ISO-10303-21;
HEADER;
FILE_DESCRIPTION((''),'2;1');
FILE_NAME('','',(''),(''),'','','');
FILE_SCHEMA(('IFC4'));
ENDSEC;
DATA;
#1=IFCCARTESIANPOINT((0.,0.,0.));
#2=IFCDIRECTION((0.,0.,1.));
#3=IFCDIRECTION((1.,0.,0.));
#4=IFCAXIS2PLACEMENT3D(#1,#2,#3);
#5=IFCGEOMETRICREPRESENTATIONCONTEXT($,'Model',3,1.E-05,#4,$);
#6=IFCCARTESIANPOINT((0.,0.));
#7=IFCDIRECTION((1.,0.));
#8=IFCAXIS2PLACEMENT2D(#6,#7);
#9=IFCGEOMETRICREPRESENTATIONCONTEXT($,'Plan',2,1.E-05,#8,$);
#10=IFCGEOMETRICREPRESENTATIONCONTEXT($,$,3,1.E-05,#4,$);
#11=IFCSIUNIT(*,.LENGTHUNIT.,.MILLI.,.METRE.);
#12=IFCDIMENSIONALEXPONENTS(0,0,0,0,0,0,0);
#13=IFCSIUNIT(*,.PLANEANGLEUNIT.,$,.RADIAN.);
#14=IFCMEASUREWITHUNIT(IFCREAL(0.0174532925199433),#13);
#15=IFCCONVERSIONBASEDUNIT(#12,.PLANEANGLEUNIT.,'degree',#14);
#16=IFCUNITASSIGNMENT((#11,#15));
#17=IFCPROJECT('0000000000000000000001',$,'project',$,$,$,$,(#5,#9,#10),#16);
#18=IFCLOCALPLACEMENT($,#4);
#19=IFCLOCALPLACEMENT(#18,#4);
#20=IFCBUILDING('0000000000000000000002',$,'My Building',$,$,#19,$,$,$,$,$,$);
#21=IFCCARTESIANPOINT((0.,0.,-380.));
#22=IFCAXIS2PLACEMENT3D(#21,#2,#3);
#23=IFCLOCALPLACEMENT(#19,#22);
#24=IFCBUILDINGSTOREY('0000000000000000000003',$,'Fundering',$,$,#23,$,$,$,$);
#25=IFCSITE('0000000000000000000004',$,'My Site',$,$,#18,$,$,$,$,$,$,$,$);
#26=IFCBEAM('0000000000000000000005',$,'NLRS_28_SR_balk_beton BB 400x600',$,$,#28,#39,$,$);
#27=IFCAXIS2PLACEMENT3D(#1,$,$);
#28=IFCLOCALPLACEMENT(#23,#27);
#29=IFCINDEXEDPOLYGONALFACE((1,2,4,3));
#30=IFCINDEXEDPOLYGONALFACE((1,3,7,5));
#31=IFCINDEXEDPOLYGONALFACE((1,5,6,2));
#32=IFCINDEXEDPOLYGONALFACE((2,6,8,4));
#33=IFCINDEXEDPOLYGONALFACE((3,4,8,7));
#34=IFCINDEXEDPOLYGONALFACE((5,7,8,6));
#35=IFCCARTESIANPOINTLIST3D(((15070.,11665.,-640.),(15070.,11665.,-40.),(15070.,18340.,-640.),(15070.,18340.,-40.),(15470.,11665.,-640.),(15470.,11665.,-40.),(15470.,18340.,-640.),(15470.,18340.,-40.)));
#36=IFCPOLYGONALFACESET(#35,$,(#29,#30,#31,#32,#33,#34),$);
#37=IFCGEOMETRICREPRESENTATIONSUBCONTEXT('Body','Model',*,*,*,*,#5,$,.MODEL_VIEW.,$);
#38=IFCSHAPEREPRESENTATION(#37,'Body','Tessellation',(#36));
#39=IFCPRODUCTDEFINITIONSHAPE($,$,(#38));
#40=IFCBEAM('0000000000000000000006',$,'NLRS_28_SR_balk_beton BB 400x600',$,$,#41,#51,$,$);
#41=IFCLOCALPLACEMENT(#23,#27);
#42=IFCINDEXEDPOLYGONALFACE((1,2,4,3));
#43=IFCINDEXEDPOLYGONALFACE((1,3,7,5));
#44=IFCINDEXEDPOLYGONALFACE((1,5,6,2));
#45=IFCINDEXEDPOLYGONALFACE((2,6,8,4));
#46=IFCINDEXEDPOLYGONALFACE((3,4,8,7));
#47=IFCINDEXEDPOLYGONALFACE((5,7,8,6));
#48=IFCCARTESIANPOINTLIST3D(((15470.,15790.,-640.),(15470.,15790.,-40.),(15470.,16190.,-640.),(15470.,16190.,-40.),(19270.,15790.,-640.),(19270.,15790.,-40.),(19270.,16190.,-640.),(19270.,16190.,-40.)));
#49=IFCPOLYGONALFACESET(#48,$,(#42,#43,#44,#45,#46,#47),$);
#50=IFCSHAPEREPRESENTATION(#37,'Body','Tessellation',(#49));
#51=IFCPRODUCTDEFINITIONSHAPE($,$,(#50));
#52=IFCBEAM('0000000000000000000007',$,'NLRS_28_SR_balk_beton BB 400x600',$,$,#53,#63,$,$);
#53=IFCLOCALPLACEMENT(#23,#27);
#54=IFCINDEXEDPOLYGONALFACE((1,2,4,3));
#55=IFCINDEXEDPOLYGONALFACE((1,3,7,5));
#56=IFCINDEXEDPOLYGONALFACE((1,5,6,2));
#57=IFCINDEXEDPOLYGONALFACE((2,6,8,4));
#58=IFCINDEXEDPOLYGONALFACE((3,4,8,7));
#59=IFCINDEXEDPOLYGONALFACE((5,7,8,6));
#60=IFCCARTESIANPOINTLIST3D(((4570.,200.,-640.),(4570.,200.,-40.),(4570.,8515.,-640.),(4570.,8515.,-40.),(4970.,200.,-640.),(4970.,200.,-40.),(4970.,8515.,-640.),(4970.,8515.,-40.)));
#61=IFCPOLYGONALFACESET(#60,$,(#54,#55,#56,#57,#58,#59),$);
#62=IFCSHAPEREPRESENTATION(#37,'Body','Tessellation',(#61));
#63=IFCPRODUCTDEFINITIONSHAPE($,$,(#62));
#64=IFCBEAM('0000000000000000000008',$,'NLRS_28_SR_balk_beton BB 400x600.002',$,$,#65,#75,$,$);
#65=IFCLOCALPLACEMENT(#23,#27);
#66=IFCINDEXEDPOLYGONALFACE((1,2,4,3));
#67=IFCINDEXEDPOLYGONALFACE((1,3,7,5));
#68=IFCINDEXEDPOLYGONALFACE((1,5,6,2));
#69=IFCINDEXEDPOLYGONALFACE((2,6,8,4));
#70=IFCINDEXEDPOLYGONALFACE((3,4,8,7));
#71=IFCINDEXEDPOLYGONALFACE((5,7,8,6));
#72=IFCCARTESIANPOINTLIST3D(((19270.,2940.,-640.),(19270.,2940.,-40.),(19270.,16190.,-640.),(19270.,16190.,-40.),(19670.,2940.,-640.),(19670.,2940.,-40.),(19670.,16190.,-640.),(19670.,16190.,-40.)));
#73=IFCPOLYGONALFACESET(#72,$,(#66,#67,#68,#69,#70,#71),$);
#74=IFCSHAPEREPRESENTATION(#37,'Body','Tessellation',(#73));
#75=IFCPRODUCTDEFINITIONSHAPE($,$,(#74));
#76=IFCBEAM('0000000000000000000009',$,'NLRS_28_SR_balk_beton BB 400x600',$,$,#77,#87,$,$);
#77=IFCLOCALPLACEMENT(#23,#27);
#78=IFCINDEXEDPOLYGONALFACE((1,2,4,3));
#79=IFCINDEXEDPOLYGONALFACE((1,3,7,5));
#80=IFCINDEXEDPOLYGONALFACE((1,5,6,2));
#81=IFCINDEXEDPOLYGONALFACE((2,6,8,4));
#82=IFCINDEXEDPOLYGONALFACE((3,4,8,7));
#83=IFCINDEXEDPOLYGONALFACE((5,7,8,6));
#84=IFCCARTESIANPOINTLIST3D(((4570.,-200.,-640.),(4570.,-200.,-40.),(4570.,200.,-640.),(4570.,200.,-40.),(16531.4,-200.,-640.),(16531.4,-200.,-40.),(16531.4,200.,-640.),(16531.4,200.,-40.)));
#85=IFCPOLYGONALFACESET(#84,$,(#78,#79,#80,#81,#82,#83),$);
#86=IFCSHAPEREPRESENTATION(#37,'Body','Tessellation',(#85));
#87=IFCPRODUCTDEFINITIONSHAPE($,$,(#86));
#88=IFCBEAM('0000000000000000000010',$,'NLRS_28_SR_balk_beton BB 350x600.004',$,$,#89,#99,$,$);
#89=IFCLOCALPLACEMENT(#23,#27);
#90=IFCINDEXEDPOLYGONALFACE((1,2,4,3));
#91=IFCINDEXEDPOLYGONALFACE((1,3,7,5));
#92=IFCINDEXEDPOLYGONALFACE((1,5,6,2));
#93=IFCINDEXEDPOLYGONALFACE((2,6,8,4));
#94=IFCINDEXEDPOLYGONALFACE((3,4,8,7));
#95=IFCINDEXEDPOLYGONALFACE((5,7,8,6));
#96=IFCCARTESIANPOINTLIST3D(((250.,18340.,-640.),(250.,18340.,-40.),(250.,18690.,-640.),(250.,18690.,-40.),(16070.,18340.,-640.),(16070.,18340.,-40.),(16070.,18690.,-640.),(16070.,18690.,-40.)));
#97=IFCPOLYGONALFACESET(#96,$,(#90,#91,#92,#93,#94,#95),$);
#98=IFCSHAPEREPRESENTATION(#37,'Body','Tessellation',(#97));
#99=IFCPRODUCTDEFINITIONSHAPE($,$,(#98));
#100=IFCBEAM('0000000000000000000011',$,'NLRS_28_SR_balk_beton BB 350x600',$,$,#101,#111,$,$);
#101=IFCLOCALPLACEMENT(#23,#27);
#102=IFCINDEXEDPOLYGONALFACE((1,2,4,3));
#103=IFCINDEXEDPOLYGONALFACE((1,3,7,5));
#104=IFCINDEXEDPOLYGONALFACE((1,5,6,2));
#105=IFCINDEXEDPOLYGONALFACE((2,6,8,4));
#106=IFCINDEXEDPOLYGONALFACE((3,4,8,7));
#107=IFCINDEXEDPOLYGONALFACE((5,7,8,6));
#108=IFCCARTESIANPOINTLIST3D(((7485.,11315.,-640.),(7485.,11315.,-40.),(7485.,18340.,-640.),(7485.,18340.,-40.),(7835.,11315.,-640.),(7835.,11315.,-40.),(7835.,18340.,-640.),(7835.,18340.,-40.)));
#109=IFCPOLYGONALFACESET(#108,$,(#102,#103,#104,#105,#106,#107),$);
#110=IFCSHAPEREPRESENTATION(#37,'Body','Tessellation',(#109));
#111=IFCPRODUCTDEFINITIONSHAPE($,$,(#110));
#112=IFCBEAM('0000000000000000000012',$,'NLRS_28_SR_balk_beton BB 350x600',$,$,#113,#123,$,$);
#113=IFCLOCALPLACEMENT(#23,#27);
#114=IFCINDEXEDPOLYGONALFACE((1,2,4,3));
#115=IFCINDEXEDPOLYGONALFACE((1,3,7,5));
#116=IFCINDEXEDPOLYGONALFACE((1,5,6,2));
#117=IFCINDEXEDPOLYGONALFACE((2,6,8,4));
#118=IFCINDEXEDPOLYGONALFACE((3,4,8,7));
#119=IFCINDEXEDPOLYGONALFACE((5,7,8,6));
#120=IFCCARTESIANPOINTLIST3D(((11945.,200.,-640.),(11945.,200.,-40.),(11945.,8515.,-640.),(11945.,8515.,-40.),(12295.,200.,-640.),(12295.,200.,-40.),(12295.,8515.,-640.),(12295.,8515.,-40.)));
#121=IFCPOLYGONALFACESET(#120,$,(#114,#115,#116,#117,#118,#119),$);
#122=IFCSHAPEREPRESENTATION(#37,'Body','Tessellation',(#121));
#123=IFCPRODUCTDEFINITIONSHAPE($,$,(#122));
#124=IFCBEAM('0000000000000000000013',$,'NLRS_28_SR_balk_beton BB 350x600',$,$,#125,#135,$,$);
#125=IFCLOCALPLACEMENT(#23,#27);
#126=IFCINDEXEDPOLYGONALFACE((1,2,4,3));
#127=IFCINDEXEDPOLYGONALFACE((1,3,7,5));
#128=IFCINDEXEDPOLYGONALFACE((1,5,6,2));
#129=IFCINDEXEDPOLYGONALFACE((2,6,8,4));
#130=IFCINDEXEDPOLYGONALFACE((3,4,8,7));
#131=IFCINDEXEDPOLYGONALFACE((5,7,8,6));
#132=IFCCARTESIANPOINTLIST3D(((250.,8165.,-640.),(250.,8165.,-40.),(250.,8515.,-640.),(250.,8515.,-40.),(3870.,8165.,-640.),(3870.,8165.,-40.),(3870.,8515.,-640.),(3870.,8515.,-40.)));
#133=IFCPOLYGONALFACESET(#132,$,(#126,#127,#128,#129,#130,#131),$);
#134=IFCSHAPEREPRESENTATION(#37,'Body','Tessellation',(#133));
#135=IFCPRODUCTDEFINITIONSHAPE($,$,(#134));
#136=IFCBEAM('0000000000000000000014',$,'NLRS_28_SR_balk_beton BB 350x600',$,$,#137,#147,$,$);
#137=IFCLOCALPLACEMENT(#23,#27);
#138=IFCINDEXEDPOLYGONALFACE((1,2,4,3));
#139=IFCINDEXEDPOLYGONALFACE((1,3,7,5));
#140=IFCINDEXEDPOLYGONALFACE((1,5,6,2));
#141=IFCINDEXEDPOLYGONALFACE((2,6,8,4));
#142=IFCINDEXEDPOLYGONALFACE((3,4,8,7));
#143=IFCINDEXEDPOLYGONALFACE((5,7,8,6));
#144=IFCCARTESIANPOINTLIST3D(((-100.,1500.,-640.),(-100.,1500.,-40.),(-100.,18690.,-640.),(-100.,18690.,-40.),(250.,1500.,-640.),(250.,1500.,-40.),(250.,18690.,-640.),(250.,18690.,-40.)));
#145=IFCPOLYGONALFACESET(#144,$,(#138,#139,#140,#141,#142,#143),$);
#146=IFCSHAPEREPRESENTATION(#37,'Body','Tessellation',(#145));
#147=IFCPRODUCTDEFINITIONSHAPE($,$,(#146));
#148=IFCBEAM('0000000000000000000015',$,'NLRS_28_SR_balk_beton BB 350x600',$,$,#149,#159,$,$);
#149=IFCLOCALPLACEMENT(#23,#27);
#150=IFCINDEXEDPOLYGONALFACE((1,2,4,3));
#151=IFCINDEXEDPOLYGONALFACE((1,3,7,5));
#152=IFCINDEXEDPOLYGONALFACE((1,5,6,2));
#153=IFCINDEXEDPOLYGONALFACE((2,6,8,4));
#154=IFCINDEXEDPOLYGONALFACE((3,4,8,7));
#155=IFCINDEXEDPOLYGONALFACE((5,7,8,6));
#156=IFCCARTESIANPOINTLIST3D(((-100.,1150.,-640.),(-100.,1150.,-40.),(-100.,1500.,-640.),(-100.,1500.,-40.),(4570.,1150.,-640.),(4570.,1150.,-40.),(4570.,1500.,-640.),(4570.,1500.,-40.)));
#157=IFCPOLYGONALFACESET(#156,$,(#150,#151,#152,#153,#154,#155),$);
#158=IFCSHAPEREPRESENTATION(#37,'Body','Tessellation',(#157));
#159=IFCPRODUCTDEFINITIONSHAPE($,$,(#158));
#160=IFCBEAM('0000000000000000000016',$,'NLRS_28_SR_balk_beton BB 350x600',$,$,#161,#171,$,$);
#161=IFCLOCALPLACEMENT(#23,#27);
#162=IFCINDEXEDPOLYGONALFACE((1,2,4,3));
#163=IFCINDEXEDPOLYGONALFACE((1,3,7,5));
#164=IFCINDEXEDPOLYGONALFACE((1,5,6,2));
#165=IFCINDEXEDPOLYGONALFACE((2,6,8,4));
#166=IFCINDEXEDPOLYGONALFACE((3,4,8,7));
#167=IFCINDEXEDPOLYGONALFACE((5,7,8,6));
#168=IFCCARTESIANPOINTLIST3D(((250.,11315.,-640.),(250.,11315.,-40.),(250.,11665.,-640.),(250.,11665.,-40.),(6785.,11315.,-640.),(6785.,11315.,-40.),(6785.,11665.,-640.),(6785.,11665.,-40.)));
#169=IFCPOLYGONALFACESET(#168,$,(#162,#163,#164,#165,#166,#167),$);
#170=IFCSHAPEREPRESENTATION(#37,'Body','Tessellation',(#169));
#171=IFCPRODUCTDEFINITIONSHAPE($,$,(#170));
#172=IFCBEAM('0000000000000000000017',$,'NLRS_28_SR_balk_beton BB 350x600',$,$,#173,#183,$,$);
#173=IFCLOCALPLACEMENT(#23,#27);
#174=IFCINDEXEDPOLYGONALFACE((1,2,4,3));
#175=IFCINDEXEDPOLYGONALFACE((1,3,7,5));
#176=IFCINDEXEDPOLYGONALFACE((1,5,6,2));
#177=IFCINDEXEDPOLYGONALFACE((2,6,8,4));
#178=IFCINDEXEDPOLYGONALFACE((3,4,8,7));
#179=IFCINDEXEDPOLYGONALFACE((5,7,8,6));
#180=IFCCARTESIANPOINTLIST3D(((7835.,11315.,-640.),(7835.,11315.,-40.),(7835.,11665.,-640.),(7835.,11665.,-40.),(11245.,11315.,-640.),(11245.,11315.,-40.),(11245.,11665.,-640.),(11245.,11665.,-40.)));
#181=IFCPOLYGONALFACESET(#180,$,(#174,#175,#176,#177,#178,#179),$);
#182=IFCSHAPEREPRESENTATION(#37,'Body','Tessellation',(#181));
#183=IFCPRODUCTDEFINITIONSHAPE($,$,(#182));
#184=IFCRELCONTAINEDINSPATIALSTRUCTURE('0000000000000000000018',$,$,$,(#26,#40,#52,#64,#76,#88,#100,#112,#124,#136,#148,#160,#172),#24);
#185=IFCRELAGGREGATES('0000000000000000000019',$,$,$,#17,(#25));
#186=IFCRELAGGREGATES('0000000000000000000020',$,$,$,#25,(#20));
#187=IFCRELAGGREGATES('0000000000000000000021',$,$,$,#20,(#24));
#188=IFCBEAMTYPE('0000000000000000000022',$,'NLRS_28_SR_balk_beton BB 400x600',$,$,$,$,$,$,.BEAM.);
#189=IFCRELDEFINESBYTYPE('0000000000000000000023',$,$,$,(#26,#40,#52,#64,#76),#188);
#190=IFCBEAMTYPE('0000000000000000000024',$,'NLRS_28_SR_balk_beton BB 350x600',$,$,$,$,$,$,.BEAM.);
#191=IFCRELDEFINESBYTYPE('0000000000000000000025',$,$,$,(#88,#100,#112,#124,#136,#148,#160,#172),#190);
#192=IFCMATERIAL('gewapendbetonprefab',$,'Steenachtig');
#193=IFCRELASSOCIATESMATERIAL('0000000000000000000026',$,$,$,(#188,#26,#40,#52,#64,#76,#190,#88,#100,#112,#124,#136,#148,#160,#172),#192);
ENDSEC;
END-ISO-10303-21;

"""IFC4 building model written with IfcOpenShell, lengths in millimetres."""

from ifc_helpers import new_model, entity, si_unit, converted_unit, frame, origin_with_axes, origin_2d_with_axis, place, context, subcontext, project, spatial, rectangle, extrude, material, material_profile, profile_set, profile_usage, type_object, element, save


model = new_model("IFC4")

# Units and contexts
model_context = context("Model", 3, precision=1e-05, world=origin_with_axes())
plan_context = context("Plan", 2, precision=1e-05, world=origin_2d_with_axis())
context_of_model = context(None, 3, precision=1e-05, world=origin_with_axes())
body_context = subcontext(model_context, "Body", "Model", "MODEL_VIEW")
ifc_project = project(units=[si_unit("LENGTHUNIT", "METRE", prefix="MILLI"), converted_unit("PLANEANGLEUNIT", "degree", entity("IfcReal", 0.0174532925199433), si_unit("PLANEANGLEUNIT", "RADIAN"), dimensions=[0, 0, 0, 0, 0, 0, 0])], contexts=[model_context, plan_context, context_of_model])

# Site, building, storey
site_placement = place(None, origin_with_axes())
site = spatial("IfcSite", under=ifc_project, at=site_placement, Name="My Site")
building_placement = place(site_placement, origin_with_axes())
building = spatial("IfcBuilding", under=site, at=building_placement, Name="My Building")
storey_placement = place(building_placement, frame((0.0, 0.0, -380.0), z_axis=(0.0, 0.0, 1.0), x_axis=(1.0, 0.0, 0.0)))
storey = spatial("IfcBuildingStorey", under=building, at=storey_placement, Name="Fundering")

# Beams
ifc_material_1 = material(Name="gewapendbetonprefab", Category="Steenachtig")
ifc_material_profile_1 = material_profile(ifc_material_1, rectangle(XDim=400.0, YDim=600.0))
ifc_profile_set_1 = profile_set([ifc_material_profile_1], Name="NLRS_28_SR_balk_beton BB 400x600")
ifc_profile_usage_1 = profile_usage(ifc_profile_set_1, cardinal=8)
beam_type_1 = type_object("IfcBeamType", Name="NLRS_28_SR_balk_beton BB 400x600", PredefinedType="BEAM", material=ifc_profile_set_1)
beam_1_placement = place(storey_placement, frame((15270.0, 11665.0, -40.0), z_axis=(0.0, 1.0, 0.0), x_axis=(-1.0, 0.0, 0.0)))
element("IfcBeam", 1, at=beam_1_placement, inside=storey, type_object=beam_type_1, material=ifc_profile_usage_1, Name="NLRS_28_SR_balk_beton BB 400x600", context=body_context, shape_type="SweptSolid", body=[
    extrude(rectangle(XDim=400.0, YDim=600.0), frame((0.0, -300.0, 0.0), z_axis=(0.0, 0.0, 1.0), x_axis=(1.0, 0.0, 0.0)), (0.0, 0.0, 1.0), 6675.0),
])
ifc_profile_usage_2 = profile_usage(ifc_profile_set_1, cardinal=8)
beam_2_placement = place(storey_placement, frame((19270.0, 15990.0, -40.0), z_axis=(-1.0, 0.0, 0.0), x_axis=(0.0, -1.0, 0.0)))
element("IfcBeam", 2, at=beam_2_placement, inside=storey, type_object=beam_type_1, material=ifc_profile_usage_2, Name="NLRS_28_SR_balk_beton BB 400x600", context=body_context, shape_type="SweptSolid", body=[
    extrude(rectangle(XDim=400.0, YDim=600.0), frame((0.0, -300.0, 0.0), z_axis=(0.0, 0.0, 1.0), x_axis=(1.0, 0.0, 0.0)), (0.0, 0.0, 1.0), 3800.0),
])
ifc_profile_usage_3 = profile_usage(ifc_profile_set_1, cardinal=8)
beam_3_placement = place(storey_placement, frame((4770.0, 200.0, -40.0), z_axis=(0.0, 1.0, 0.0), x_axis=(-1.0, 0.0, 0.0)))
element("IfcBeam", 3, at=beam_3_placement, inside=storey, type_object=beam_type_1, material=ifc_profile_usage_3, Name="NLRS_28_SR_balk_beton BB 400x600", context=body_context, shape_type="SweptSolid", body=[
    extrude(rectangle(XDim=400.0, YDim=600.0), frame((0.0, -300.0, 0.0), z_axis=(0.0, 0.0, 1.0), x_axis=(1.0, 0.0, 0.0)), (0.0, 0.0, 1.0), 8315.0),
])
ifc_profile_usage_4 = profile_usage(ifc_profile_set_1, cardinal=8)
beam_4_placement = place(storey_placement, frame((19470.0, 2940.0, -40.0), z_axis=(0.0, 1.0, 0.0), x_axis=(-1.0, 0.0, 0.0)))
element("IfcBeam", 4, at=beam_4_placement, inside=storey, type_object=beam_type_1, material=ifc_profile_usage_4, Name="NLRS_28_SR_balk_beton BB 400x600.002", context=body_context, shape_type="SweptSolid", body=[
    extrude(rectangle(XDim=400.0, YDim=600.0), frame((0.0, -300.0, 0.0), z_axis=(0.0, 0.0, 1.0), x_axis=(1.0, 0.0, 0.0)), (0.0, 0.0, 1.0), 13250.0),
])
ifc_profile_usage_5 = profile_usage(ifc_profile_set_1, cardinal=8)
beam_5_placement = place(storey_placement, frame((4570.0, 0.0, -40.0), z_axis=(1.0, 0.0, 0.0), x_axis=(0.0, 1.0, 0.0)))
element("IfcBeam", 5, at=beam_5_placement, inside=storey, type_object=beam_type_1, material=ifc_profile_usage_5, Name="NLRS_28_SR_balk_beton BB 400x600", context=body_context, shape_type="SweptSolid", body=[
    extrude(rectangle(XDim=400.0, YDim=600.0), frame((0.0, -300.0, 0.0), z_axis=(0.0, 0.0, 1.0), x_axis=(1.0, 0.0, 0.0)), (0.0, 0.0, 1.0), 11961.4),
])
ifc_material_profile_2 = material_profile(ifc_material_1, rectangle(XDim=350.0, YDim=600.0))
ifc_profile_set_2 = profile_set([ifc_material_profile_2], Name="NLRS_28_SR_balk_beton BB 350x600")
ifc_profile_usage_6 = profile_usage(ifc_profile_set_2, cardinal=8)
beam_type_2 = type_object("IfcBeamType", Name="NLRS_28_SR_balk_beton BB 350x600", PredefinedType="BEAM", material=ifc_profile_set_2)
beam_6_placement = place(storey_placement, frame((250.0, 18515.0, -40.0), z_axis=(1.0, 0.0, 0.0), x_axis=(0.0, 1.0, 0.0)))
element("IfcBeam", 6, at=beam_6_placement, inside=storey, type_object=beam_type_2, material=ifc_profile_usage_6, Name="NLRS_28_SR_balk_beton BB 350x600.004", context=body_context, shape_type="SweptSolid", body=[
    extrude(rectangle(XDim=350.0, YDim=600.0), frame((0.0, -300.0, 0.0), z_axis=(0.0, 0.0, 1.0), x_axis=(1.0, 0.0, 0.0)), (0.0, 0.0, 1.0), 15820.0),
])
ifc_profile_usage_7 = profile_usage(ifc_profile_set_2, cardinal=8)
beam_7_placement = place(storey_placement, frame((7660.0, 11315.0, -40.0), z_axis=(0.0, 1.0, 0.0), x_axis=(-1.0, 0.0, 0.0)))
element("IfcBeam", 7, at=beam_7_placement, inside=storey, type_object=beam_type_2, material=ifc_profile_usage_7, Name="NLRS_28_SR_balk_beton BB 350x600", context=body_context, shape_type="SweptSolid", body=[
    extrude(rectangle(XDim=350.0, YDim=600.0), frame((0.0, -300.0, 0.0), z_axis=(0.0, 0.0, 1.0), x_axis=(1.0, 0.0, 0.0)), (0.0, 0.0, 1.0), 7025.0),
])
ifc_profile_usage_8 = profile_usage(ifc_profile_set_2)
beam_8_placement = place(storey_placement, frame((12120.0, 200.0, -340.0), z_axis=(0.0, 1.0, 0.0), x_axis=(-1.0, 0.0, 0.0)))
element("IfcBeam", 8, at=beam_8_placement, inside=storey, type_object=beam_type_2, material=ifc_profile_usage_8, Name="NLRS_28_SR_balk_beton BB 350x600", context=body_context, shape_type="SweptSolid", body=[
    extrude(rectangle(XDim=350.0, YDim=600.0), origin_with_axes(), (0.0, 0.0, 1.0), 8315.0),
])
ifc_profile_usage_9 = profile_usage(ifc_profile_set_2, cardinal=8)
beam_9_placement = place(storey_placement, frame((3870.0, 8340.0, -40.0), z_axis=(-1.0, 0.0, 0.0), x_axis=(0.0, -1.0, 0.0)))
element("IfcBeam", 9, at=beam_9_placement, inside=storey, type_object=beam_type_2, material=ifc_profile_usage_9, Name="NLRS_28_SR_balk_beton BB 350x600", context=body_context, shape_type="SweptSolid", body=[
    extrude(rectangle(XDim=350.0, YDim=600.0), frame((0.0, -300.0, 0.0), z_axis=(0.0, 0.0, 1.0), x_axis=(1.0, 0.0, 0.0)), (0.0, 0.0, 1.0), 3620.0),
])
ifc_profile_usage_10 = profile_usage(ifc_profile_set_2, cardinal=8)
beam_10_placement = place(storey_placement, frame((75.0, 1500.0, -40.0), z_axis=(0.0, 1.0, 0.0), x_axis=(-1.0, 0.0, 0.0)))
element("IfcBeam", 10, at=beam_10_placement, inside=storey, type_object=beam_type_2, material=ifc_profile_usage_10, Name="NLRS_28_SR_balk_beton BB 350x600", context=body_context, shape_type="SweptSolid", body=[
    extrude(rectangle(XDim=350.0, YDim=600.0), frame((0.0, -300.0, 0.0), z_axis=(0.0, 0.0, 1.0), x_axis=(1.0, 0.0, 0.0)), (0.0, 0.0, 1.0), 17190.0),
])
ifc_profile_usage_11 = profile_usage(ifc_profile_set_2, cardinal=8)
beam_11_placement = place(storey_placement, frame((4570.0, 1325.0, -40.0), z_axis=(-1.0, 0.0, 0.0), x_axis=(0.0, -1.0, 0.0)))
element("IfcBeam", 11, at=beam_11_placement, inside=storey, type_object=beam_type_2, material=ifc_profile_usage_11, Name="NLRS_28_SR_balk_beton BB 350x600", context=body_context, shape_type="SweptSolid", body=[
    extrude(rectangle(XDim=350.0, YDim=600.0), frame((0.0, -300.0, 0.0), z_axis=(0.0, 0.0, 1.0), x_axis=(1.0, 0.0, 0.0)), (0.0, 0.0, 1.0), 4670.0),
])
ifc_profile_usage_12 = profile_usage(ifc_profile_set_2, cardinal=8)
beam_12_placement = place(storey_placement, frame((6785.0, 11490.0, -40.0), z_axis=(-1.0, 0.0, 0.0), x_axis=(0.0, -1.0, 0.0)))
element("IfcBeam", 12, at=beam_12_placement, inside=storey, type_object=beam_type_2, material=ifc_profile_usage_12, Name="NLRS_28_SR_balk_beton BB 350x600", context=body_context, shape_type="SweptSolid", body=[
    extrude(rectangle(XDim=350.0, YDim=600.0), frame((0.0, -300.0, 0.0), z_axis=(0.0, 0.0, 1.0), x_axis=(1.0, 0.0, 0.0)), (0.0, 0.0, 1.0), 6535.0),
])
ifc_profile_usage_13 = profile_usage(ifc_profile_set_2, cardinal=8)
beam_13_placement = place(storey_placement, frame((11245.0, 11490.0, -40.0), z_axis=(-1.0, 0.0, 0.0), x_axis=(0.0, -1.0, 0.0)))
element("IfcBeam", 13, at=beam_13_placement, inside=storey, type_object=beam_type_2, material=ifc_profile_usage_13, Name="NLRS_28_SR_balk_beton BB 350x600", context=body_context, shape_type="SweptSolid", body=[
    extrude(rectangle(XDim=350.0, YDim=600.0), frame((0.0, -300.0, 0.0), z_axis=(0.0, 0.0, 1.0), x_axis=(1.0, 0.0, 0.0)), (0.0, 0.0, 1.0), 3410.0),
])

save(model, "model.ifc")
